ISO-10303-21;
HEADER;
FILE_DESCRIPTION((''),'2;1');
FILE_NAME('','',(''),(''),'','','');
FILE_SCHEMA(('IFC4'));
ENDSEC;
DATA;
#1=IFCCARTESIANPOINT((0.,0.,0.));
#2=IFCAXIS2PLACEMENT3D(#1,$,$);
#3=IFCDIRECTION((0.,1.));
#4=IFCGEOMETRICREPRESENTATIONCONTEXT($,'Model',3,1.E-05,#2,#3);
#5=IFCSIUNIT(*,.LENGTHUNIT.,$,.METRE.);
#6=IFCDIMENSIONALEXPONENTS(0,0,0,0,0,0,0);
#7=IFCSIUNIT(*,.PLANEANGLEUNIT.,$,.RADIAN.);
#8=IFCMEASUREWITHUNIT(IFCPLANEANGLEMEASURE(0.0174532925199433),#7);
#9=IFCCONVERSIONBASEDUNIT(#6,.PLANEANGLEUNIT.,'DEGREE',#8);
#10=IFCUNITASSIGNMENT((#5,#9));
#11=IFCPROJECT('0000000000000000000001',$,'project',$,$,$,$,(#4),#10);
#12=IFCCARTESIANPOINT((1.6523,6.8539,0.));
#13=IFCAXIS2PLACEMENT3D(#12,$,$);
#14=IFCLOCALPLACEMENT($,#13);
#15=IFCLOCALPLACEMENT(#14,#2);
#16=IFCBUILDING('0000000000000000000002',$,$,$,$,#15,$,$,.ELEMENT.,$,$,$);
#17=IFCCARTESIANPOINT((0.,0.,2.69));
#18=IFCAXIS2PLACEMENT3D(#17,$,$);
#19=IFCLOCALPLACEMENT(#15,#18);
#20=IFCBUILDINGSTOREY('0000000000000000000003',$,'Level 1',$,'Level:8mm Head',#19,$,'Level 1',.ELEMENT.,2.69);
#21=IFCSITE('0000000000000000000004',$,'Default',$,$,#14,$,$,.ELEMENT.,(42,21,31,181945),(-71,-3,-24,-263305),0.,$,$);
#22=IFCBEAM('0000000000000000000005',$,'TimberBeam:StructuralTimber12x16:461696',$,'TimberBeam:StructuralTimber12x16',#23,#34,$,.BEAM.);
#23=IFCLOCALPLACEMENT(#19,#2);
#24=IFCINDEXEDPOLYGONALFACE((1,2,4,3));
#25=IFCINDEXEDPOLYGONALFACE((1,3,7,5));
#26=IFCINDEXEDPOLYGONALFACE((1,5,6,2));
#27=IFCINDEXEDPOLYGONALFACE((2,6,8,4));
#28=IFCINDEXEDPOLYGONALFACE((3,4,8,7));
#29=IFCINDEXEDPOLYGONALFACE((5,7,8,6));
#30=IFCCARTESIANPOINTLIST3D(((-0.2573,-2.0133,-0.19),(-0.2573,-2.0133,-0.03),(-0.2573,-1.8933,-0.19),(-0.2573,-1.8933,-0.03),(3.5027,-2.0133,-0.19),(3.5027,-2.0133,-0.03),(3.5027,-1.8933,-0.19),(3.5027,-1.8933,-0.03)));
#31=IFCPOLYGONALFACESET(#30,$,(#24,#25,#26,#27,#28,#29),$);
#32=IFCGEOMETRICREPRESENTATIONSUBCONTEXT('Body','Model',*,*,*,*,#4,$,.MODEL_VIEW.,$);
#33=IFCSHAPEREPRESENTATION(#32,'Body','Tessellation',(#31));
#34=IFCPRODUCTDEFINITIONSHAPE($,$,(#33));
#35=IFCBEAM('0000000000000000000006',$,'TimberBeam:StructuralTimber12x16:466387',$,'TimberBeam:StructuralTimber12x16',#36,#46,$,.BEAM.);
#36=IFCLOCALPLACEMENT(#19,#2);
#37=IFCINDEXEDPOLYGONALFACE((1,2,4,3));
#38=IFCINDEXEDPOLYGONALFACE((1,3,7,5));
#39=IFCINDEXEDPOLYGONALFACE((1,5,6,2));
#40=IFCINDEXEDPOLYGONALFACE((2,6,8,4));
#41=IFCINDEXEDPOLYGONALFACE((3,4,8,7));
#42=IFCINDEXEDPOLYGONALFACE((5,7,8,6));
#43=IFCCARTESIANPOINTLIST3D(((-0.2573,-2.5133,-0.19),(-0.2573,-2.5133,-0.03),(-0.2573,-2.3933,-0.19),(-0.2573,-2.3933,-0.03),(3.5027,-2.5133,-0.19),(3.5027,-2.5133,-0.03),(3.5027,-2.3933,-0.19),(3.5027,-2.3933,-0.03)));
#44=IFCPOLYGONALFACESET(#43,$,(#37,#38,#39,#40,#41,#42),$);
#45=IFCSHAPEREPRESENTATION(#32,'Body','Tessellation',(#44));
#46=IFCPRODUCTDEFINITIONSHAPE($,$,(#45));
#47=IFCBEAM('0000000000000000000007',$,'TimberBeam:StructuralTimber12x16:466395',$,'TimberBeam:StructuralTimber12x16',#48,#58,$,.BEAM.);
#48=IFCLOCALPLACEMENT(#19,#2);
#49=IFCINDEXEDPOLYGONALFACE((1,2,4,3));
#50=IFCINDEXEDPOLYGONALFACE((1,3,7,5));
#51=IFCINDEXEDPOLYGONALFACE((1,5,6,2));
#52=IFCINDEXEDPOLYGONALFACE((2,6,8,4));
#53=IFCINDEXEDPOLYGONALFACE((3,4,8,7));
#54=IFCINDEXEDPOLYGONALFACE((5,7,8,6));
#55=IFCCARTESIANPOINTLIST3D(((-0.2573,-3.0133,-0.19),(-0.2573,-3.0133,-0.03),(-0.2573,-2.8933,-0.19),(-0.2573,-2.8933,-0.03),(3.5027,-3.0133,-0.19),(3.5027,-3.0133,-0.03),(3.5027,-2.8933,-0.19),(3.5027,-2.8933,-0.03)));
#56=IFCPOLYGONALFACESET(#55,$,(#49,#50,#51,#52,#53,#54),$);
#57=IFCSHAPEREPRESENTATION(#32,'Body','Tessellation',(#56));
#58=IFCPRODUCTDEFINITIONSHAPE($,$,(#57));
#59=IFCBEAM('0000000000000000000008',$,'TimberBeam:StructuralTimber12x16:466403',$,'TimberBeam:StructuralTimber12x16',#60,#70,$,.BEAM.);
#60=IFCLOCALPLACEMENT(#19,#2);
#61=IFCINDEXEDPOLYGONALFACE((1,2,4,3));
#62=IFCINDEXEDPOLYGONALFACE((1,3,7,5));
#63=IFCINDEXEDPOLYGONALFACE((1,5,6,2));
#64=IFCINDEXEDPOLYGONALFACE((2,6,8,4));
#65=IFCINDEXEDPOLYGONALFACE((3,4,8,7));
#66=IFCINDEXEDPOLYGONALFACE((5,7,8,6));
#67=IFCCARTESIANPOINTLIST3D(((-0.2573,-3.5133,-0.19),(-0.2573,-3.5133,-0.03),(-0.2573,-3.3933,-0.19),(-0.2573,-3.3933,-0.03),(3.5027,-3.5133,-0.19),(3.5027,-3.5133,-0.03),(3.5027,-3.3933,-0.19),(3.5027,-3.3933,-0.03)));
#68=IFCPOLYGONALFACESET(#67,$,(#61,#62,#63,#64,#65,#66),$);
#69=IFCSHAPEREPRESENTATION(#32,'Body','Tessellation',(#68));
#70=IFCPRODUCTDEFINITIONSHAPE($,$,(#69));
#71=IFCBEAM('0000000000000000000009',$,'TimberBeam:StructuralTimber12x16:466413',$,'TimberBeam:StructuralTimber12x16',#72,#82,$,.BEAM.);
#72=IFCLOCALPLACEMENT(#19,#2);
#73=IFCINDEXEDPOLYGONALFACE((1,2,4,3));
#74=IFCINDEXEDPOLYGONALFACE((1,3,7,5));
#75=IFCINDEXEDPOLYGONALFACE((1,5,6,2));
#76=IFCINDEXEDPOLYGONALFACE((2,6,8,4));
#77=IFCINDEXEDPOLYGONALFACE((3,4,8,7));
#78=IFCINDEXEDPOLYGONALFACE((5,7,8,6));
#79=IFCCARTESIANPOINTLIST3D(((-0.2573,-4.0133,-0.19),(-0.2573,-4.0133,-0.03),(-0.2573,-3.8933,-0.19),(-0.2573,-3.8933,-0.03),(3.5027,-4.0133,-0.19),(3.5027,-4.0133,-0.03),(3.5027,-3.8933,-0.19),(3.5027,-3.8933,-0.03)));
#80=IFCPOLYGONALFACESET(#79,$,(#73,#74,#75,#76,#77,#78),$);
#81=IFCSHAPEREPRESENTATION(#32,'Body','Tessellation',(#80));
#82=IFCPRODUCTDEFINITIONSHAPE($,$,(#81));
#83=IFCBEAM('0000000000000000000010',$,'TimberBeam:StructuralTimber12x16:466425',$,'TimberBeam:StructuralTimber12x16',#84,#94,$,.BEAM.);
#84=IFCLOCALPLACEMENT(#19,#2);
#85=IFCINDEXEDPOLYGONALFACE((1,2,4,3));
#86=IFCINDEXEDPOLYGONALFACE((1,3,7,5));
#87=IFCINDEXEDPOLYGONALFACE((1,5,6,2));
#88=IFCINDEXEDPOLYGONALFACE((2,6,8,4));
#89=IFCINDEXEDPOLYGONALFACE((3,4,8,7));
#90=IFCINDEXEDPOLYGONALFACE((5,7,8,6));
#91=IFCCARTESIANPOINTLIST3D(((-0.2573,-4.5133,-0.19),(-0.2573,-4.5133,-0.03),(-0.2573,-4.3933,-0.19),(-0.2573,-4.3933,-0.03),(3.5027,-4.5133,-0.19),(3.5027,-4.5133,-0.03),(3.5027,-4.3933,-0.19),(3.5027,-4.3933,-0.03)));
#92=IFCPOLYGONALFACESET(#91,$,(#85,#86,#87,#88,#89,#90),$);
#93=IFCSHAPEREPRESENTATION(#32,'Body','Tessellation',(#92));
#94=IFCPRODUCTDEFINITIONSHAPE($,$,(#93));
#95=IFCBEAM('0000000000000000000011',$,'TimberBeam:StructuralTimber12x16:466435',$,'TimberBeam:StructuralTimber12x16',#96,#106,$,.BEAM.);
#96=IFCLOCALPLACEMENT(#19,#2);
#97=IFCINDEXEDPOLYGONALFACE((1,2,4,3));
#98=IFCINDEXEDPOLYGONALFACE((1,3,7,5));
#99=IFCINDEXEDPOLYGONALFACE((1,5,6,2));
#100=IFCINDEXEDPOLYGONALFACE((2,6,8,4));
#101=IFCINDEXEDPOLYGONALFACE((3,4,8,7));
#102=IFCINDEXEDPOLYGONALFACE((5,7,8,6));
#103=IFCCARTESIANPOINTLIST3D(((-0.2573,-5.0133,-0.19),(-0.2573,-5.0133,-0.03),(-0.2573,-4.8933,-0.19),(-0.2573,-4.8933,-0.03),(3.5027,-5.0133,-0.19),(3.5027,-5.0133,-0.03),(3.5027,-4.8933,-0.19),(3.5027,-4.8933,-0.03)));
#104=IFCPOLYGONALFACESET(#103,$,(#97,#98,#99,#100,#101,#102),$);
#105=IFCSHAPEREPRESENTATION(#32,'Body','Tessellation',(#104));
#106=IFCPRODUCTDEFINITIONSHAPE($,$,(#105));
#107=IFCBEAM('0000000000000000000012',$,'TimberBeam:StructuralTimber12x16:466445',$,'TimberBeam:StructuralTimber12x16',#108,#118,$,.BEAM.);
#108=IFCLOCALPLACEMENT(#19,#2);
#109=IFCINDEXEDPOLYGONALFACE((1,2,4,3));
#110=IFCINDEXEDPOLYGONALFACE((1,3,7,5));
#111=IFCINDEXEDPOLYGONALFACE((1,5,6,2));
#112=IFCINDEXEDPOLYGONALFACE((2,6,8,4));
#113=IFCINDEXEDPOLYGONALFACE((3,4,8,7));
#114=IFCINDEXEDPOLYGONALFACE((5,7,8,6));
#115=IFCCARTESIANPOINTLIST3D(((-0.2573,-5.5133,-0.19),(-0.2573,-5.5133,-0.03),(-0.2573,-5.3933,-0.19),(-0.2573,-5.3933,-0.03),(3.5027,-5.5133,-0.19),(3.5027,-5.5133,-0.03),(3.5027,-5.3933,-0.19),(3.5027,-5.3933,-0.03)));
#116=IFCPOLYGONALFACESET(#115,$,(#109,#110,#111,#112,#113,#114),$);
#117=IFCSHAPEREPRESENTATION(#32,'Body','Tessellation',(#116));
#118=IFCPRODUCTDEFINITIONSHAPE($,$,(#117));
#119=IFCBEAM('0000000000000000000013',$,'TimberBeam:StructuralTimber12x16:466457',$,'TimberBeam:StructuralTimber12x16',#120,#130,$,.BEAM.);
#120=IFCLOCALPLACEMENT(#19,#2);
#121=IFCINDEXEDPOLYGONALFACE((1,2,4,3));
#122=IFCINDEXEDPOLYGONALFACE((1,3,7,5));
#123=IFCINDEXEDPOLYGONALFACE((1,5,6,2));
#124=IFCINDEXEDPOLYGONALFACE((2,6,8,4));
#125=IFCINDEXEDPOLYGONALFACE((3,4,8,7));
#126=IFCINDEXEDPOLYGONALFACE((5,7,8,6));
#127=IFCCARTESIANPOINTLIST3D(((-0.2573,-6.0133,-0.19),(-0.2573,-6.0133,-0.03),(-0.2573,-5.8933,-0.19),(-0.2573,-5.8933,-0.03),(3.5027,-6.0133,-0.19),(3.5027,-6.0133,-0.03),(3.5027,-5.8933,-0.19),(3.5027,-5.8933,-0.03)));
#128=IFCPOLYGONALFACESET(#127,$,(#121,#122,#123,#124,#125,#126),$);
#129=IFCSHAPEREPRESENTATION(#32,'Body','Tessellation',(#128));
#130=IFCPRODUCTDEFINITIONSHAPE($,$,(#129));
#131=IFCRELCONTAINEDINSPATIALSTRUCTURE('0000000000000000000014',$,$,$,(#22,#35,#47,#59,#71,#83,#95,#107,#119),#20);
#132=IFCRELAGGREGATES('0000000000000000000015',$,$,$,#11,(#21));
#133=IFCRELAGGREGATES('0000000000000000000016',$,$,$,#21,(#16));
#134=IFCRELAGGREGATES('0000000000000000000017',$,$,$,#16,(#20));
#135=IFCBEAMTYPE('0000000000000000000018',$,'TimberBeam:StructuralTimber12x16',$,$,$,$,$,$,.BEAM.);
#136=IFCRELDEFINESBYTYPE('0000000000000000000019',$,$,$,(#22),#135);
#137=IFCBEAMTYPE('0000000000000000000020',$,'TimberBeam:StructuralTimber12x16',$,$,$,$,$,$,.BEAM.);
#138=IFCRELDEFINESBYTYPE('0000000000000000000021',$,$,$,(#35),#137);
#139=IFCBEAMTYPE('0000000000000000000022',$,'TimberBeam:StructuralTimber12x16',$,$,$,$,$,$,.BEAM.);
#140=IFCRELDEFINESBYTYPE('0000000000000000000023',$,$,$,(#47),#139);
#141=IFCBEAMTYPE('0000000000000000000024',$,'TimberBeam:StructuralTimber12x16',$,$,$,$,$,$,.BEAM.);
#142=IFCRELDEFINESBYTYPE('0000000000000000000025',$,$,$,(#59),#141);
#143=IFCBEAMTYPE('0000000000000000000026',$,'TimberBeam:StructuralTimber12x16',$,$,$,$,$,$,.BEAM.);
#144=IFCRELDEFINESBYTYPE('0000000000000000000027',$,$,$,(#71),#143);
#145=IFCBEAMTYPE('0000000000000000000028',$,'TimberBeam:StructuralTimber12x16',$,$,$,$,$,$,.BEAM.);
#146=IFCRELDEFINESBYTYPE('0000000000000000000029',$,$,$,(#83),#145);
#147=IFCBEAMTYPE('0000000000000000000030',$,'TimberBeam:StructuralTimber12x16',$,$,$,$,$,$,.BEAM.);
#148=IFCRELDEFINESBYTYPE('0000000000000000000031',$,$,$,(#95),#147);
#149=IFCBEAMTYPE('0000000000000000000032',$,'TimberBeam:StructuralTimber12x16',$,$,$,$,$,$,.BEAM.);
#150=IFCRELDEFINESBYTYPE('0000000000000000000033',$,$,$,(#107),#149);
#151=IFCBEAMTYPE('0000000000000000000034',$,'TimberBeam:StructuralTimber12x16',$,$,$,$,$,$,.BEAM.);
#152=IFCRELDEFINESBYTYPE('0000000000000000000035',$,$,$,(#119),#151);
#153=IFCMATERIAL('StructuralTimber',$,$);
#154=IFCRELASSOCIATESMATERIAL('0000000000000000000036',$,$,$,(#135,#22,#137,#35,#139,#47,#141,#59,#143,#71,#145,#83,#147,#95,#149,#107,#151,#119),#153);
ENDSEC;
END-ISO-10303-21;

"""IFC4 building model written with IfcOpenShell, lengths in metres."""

from ifc_helpers import new_model, entity, si_unit, converted_unit, direction, frame, origin, place, context, subcontext, project, spatial, indexed_curve, outline, extrude, source, transform, mapped, material, type_object, type_shapes, element, save


model = new_model("IFC4")

# Units and contexts
model_context = context("Model", 3, precision=1e-05, world=origin(), true_north=direction((0.0, 1.0)))
body_context = subcontext(model_context, "Body", "Model", "MODEL_VIEW")
ifc_project = project(units=[si_unit("LENGTHUNIT", "METRE"), converted_unit("PLANEANGLEUNIT", "DEGREE", entity("IfcPlaneAngleMeasure", 0.0174532925199433), si_unit("PLANEANGLEUNIT", "RADIAN"), dimensions=[0, 0, 0, 0, 0, 0, 0])], contexts=[model_context])

# Site, building, storey
site_placement = place(None, frame((1.6523, 6.8539, 0.0)))
site = spatial("IfcSite", under=ifc_project, at=site_placement, Name="Default", CompositionType="ELEMENT", RefLatitude=(42, 21, 31, 181945), RefLongitude=(-71, -3, -24, -263305), RefElevation=0.0)
building_placement = place(site_placement, origin())
building = spatial("IfcBuilding", under=site, at=building_placement, CompositionType="ELEMENT")
storey_placement = place(building_placement, frame((0.0, 0.0, 2.69)))
storey = spatial("IfcBuildingStorey", under=building, at=storey_placement, Name="Level 1", ObjectType="Level:8mm Head", LongName="Level 1", CompositionType="ELEMENT", Elevation=2.69)

# Beams
ifc_material = material(Name="StructuralTimber")
beam_type_1 = type_object("IfcBeamType", Name="TimberBeam:StructuralTimber12x16", PredefinedType="BEAM", material=ifc_material)
shared_shape_1 = source(origin(), body_context, "Body", "SweptSolid", [
    extrude(outline(indexed_curve([(-0.08, -0.06), (0.08, -0.06), (0.08, 0.06), (-0.08, 0.06), (-0.08, -0.06)], self_intersect=False)), frame((-0.2573, -1.9533, 2.58), z_axis=(1.0, 0.0, 0.0), x_axis=(0.0, 0.0, -1.0)), (0.0, 0.0, 1.0), 3.76),
])
type_shapes(beam_type_1, [shared_shape_1])
beam_1_placement = place(storey_placement, frame((0.0, 0.0, -2.69)))
element("IfcBeam", 1, at=beam_1_placement, inside=storey, type_object=beam_type_1, material=ifc_material, Name="TimberBeam:StructuralTimber12x16:461696", ObjectType="TimberBeam:StructuralTimber12x16", PredefinedType="BEAM", context=body_context, shape_type="MappedRepresentation", body=[
    mapped(shared_shape_1, transform((0.0, 0.0, 0.0), scale=1.0)),
])
beam_type_2 = type_object("IfcBeamType", Name="TimberBeam:StructuralTimber12x16", PredefinedType="BEAM", material=ifc_material)
shared_shape_2 = source(origin(), body_context, "Body", "SweptSolid", [
    extrude(outline(indexed_curve([(-0.08, -0.06), (0.08, -0.06), (0.08, 0.06), (-0.08, 0.06), (-0.08, -0.06)], self_intersect=False)), frame((-0.2573, -2.4533, 2.58), z_axis=(1.0, 0.0, 0.0), x_axis=(0.0, 0.0, -1.0)), (0.0, 0.0, 1.0), 3.76),
])
type_shapes(beam_type_2, [shared_shape_2])
beam_2_placement = place(storey_placement, frame((0.0, 0.0, -2.69)))
element("IfcBeam", 2, at=beam_2_placement, inside=storey, type_object=beam_type_2, material=ifc_material, Name="TimberBeam:StructuralTimber12x16:466387", ObjectType="TimberBeam:StructuralTimber12x16", PredefinedType="BEAM", context=body_context, shape_type="MappedRepresentation", body=[
    mapped(shared_shape_2, transform((0.0, 0.0, 0.0), scale=1.0)),
])
beam_type_3 = type_object("IfcBeamType", Name="TimberBeam:StructuralTimber12x16", PredefinedType="BEAM", material=ifc_material)
shared_shape_3 = source(origin(), body_context, "Body", "SweptSolid", [
    extrude(outline(indexed_curve([(-0.08, -0.06), (0.08, -0.06), (0.08, 0.06), (-0.08, 0.06), (-0.08, -0.06)], self_intersect=False)), frame((-0.2573, -2.9533, 2.58), z_axis=(1.0, 0.0, 0.0), x_axis=(0.0, 0.0, -1.0)), (0.0, 0.0, 1.0), 3.76),
])
type_shapes(beam_type_3, [shared_shape_3])
beam_3_placement = place(storey_placement, frame((0.0, 0.0, -2.69)))
element("IfcBeam", 3, at=beam_3_placement, inside=storey, type_object=beam_type_3, material=ifc_material, Name="TimberBeam:StructuralTimber12x16:466395", ObjectType="TimberBeam:StructuralTimber12x16", PredefinedType="BEAM", context=body_context, shape_type="MappedRepresentation", body=[
    mapped(shared_shape_3, transform((0.0, 0.0, 0.0), scale=1.0)),
])
beam_type_4 = type_object("IfcBeamType", Name="TimberBeam:StructuralTimber12x16", PredefinedType="BEAM", material=ifc_material)
shared_shape_4 = source(origin(), body_context, "Body", "SweptSolid", [
    extrude(outline(indexed_curve([(-0.08, -0.06), (0.08, -0.06), (0.08, 0.06), (-0.08, 0.06), (-0.08, -0.06)], self_intersect=False)), frame((-0.2573, -3.4533, 2.58), z_axis=(1.0, 0.0, 0.0), x_axis=(0.0, 0.0, -1.0)), (0.0, 0.0, 1.0), 3.76),
])
type_shapes(beam_type_4, [shared_shape_4])
beam_4_placement = place(storey_placement, frame((0.0, 0.0, -2.69)))
element("IfcBeam", 4, at=beam_4_placement, inside=storey, type_object=beam_type_4, material=ifc_material, Name="TimberBeam:StructuralTimber12x16:466403", ObjectType="TimberBeam:StructuralTimber12x16", PredefinedType="BEAM", context=body_context, shape_type="MappedRepresentation", body=[
    mapped(shared_shape_4, transform((0.0, 0.0, 0.0), scale=1.0)),
])
beam_type_5 = type_object("IfcBeamType", Name="TimberBeam:StructuralTimber12x16", PredefinedType="BEAM", material=ifc_material)
shared_shape_5 = source(origin(), body_context, "Body", "SweptSolid", [
    extrude(outline(indexed_curve([(-0.08, -0.06), (0.08, -0.06), (0.08, 0.06), (-0.08, 0.06), (-0.08, -0.06)], self_intersect=False)), frame((-0.2573, -3.9533, 2.58), z_axis=(1.0, 0.0, 0.0), x_axis=(0.0, 0.0, -1.0)), (0.0, 0.0, 1.0), 3.76),
])
type_shapes(beam_type_5, [shared_shape_5])
beam_5_placement = place(storey_placement, frame((0.0, 0.0, -2.69)))
element("IfcBeam", 5, at=beam_5_placement, inside=storey, type_object=beam_type_5, material=ifc_material, Name="TimberBeam:StructuralTimber12x16:466413", ObjectType="TimberBeam:StructuralTimber12x16", PredefinedType="BEAM", context=body_context, shape_type="MappedRepresentation", body=[
    mapped(shared_shape_5, transform((0.0, 0.0, 0.0), scale=1.0)),
])
beam_type_6 = type_object("IfcBeamType", Name="TimberBeam:StructuralTimber12x16", PredefinedType="BEAM", material=ifc_material)
shared_shape_6 = source(origin(), body_context, "Body", "SweptSolid", [
    extrude(outline(indexed_curve([(-0.08, -0.06), (0.08, -0.06), (0.08, 0.06), (-0.08, 0.06), (-0.08, -0.06)], self_intersect=False)), frame((-0.2573, -4.4533, 2.58), z_axis=(1.0, 0.0, 0.0), x_axis=(0.0, 0.0, -1.0)), (0.0, 0.0, 1.0), 3.76),
])
type_shapes(beam_type_6, [shared_shape_6])
beam_6_placement = place(storey_placement, frame((0.0, 0.0, -2.69)))
element("IfcBeam", 6, at=beam_6_placement, inside=storey, type_object=beam_type_6, material=ifc_material, Name="TimberBeam:StructuralTimber12x16:466425", ObjectType="TimberBeam:StructuralTimber12x16", PredefinedType="BEAM", context=body_context, shape_type="MappedRepresentation", body=[
    mapped(shared_shape_6, transform((0.0, 0.0, 0.0), scale=1.0)),
])
beam_type_7 = type_object("IfcBeamType", Name="TimberBeam:StructuralTimber12x16", PredefinedType="BEAM", material=ifc_material)
shared_shape_7 = source(origin(), body_context, "Body", "SweptSolid", [
    extrude(outline(indexed_curve([(-0.08, -0.06), (0.08, -0.06), (0.08, 0.06), (-0.08, 0.06), (-0.08, -0.06)], self_intersect=False)), frame((-0.2573, -4.9533, 2.58), z_axis=(1.0, 0.0, 0.0), x_axis=(0.0, 0.0, -1.0)), (0.0, 0.0, 1.0), 3.76),
])
type_shapes(beam_type_7, [shared_shape_7])
beam_7_placement = place(storey_placement, frame((0.0, 0.0, -2.69)))
element("IfcBeam", 7, at=beam_7_placement, inside=storey, type_object=beam_type_7, material=ifc_material, Name="TimberBeam:StructuralTimber12x16:466435", ObjectType="TimberBeam:StructuralTimber12x16", PredefinedType="BEAM", context=body_context, shape_type="MappedRepresentation", body=[
    mapped(shared_shape_7, transform((0.0, 0.0, 0.0), scale=1.0)),
])
beam_type_8 = type_object("IfcBeamType", Name="TimberBeam:StructuralTimber12x16", PredefinedType="BEAM", material=ifc_material)
shared_shape_8 = source(origin(), body_context, "Body", "SweptSolid", [
    extrude(outline(indexed_curve([(-0.08, -0.06), (0.08, -0.06), (0.08, 0.06), (-0.08, 0.06), (-0.08, -0.06)], self_intersect=False)), frame((-0.2573, -5.4533, 2.58), z_axis=(1.0, 0.0, 0.0), x_axis=(0.0, 0.0, -1.0)), (0.0, 0.0, 1.0), 3.76),
])
type_shapes(beam_type_8, [shared_shape_8])
beam_8_placement = place(storey_placement, frame((0.0, 0.0, -2.69)))
element("IfcBeam", 8, at=beam_8_placement, inside=storey, type_object=beam_type_8, material=ifc_material, Name="TimberBeam:StructuralTimber12x16:466445", ObjectType="TimberBeam:StructuralTimber12x16", PredefinedType="BEAM", context=body_context, shape_type="MappedRepresentation", body=[
    mapped(shared_shape_8, transform((0.0, 0.0, 0.0), scale=1.0)),
])
beam_type_9 = type_object("IfcBeamType", Name="TimberBeam:StructuralTimber12x16", PredefinedType="BEAM", material=ifc_material)
shared_shape_9 = source(origin(), body_context, "Body", "SweptSolid", [
    extrude(outline(indexed_curve([(-0.08, -0.06), (0.08, -0.06), (0.08, 0.06), (-0.08, 0.06), (-0.08, -0.06)], self_intersect=False)), frame((-0.2573, -5.9533, 2.58), z_axis=(1.0, 0.0, 0.0), x_axis=(0.0, 0.0, -1.0)), (0.0, 0.0, 1.0), 3.76),
])
type_shapes(beam_type_9, [shared_shape_9])
beam_9_placement = place(storey_placement, frame((0.0, 0.0, -2.69)))
element("IfcBeam", 9, at=beam_9_placement, inside=storey, type_object=beam_type_9, material=ifc_material, Name="TimberBeam:StructuralTimber12x16:466457", ObjectType="TimberBeam:StructuralTimber12x16", PredefinedType="BEAM", context=body_context, shape_type="MappedRepresentation", body=[
    mapped(shared_shape_9, transform((0.0, 0.0, 0.0), scale=1.0)),
])

save(model, "model.ifc")
